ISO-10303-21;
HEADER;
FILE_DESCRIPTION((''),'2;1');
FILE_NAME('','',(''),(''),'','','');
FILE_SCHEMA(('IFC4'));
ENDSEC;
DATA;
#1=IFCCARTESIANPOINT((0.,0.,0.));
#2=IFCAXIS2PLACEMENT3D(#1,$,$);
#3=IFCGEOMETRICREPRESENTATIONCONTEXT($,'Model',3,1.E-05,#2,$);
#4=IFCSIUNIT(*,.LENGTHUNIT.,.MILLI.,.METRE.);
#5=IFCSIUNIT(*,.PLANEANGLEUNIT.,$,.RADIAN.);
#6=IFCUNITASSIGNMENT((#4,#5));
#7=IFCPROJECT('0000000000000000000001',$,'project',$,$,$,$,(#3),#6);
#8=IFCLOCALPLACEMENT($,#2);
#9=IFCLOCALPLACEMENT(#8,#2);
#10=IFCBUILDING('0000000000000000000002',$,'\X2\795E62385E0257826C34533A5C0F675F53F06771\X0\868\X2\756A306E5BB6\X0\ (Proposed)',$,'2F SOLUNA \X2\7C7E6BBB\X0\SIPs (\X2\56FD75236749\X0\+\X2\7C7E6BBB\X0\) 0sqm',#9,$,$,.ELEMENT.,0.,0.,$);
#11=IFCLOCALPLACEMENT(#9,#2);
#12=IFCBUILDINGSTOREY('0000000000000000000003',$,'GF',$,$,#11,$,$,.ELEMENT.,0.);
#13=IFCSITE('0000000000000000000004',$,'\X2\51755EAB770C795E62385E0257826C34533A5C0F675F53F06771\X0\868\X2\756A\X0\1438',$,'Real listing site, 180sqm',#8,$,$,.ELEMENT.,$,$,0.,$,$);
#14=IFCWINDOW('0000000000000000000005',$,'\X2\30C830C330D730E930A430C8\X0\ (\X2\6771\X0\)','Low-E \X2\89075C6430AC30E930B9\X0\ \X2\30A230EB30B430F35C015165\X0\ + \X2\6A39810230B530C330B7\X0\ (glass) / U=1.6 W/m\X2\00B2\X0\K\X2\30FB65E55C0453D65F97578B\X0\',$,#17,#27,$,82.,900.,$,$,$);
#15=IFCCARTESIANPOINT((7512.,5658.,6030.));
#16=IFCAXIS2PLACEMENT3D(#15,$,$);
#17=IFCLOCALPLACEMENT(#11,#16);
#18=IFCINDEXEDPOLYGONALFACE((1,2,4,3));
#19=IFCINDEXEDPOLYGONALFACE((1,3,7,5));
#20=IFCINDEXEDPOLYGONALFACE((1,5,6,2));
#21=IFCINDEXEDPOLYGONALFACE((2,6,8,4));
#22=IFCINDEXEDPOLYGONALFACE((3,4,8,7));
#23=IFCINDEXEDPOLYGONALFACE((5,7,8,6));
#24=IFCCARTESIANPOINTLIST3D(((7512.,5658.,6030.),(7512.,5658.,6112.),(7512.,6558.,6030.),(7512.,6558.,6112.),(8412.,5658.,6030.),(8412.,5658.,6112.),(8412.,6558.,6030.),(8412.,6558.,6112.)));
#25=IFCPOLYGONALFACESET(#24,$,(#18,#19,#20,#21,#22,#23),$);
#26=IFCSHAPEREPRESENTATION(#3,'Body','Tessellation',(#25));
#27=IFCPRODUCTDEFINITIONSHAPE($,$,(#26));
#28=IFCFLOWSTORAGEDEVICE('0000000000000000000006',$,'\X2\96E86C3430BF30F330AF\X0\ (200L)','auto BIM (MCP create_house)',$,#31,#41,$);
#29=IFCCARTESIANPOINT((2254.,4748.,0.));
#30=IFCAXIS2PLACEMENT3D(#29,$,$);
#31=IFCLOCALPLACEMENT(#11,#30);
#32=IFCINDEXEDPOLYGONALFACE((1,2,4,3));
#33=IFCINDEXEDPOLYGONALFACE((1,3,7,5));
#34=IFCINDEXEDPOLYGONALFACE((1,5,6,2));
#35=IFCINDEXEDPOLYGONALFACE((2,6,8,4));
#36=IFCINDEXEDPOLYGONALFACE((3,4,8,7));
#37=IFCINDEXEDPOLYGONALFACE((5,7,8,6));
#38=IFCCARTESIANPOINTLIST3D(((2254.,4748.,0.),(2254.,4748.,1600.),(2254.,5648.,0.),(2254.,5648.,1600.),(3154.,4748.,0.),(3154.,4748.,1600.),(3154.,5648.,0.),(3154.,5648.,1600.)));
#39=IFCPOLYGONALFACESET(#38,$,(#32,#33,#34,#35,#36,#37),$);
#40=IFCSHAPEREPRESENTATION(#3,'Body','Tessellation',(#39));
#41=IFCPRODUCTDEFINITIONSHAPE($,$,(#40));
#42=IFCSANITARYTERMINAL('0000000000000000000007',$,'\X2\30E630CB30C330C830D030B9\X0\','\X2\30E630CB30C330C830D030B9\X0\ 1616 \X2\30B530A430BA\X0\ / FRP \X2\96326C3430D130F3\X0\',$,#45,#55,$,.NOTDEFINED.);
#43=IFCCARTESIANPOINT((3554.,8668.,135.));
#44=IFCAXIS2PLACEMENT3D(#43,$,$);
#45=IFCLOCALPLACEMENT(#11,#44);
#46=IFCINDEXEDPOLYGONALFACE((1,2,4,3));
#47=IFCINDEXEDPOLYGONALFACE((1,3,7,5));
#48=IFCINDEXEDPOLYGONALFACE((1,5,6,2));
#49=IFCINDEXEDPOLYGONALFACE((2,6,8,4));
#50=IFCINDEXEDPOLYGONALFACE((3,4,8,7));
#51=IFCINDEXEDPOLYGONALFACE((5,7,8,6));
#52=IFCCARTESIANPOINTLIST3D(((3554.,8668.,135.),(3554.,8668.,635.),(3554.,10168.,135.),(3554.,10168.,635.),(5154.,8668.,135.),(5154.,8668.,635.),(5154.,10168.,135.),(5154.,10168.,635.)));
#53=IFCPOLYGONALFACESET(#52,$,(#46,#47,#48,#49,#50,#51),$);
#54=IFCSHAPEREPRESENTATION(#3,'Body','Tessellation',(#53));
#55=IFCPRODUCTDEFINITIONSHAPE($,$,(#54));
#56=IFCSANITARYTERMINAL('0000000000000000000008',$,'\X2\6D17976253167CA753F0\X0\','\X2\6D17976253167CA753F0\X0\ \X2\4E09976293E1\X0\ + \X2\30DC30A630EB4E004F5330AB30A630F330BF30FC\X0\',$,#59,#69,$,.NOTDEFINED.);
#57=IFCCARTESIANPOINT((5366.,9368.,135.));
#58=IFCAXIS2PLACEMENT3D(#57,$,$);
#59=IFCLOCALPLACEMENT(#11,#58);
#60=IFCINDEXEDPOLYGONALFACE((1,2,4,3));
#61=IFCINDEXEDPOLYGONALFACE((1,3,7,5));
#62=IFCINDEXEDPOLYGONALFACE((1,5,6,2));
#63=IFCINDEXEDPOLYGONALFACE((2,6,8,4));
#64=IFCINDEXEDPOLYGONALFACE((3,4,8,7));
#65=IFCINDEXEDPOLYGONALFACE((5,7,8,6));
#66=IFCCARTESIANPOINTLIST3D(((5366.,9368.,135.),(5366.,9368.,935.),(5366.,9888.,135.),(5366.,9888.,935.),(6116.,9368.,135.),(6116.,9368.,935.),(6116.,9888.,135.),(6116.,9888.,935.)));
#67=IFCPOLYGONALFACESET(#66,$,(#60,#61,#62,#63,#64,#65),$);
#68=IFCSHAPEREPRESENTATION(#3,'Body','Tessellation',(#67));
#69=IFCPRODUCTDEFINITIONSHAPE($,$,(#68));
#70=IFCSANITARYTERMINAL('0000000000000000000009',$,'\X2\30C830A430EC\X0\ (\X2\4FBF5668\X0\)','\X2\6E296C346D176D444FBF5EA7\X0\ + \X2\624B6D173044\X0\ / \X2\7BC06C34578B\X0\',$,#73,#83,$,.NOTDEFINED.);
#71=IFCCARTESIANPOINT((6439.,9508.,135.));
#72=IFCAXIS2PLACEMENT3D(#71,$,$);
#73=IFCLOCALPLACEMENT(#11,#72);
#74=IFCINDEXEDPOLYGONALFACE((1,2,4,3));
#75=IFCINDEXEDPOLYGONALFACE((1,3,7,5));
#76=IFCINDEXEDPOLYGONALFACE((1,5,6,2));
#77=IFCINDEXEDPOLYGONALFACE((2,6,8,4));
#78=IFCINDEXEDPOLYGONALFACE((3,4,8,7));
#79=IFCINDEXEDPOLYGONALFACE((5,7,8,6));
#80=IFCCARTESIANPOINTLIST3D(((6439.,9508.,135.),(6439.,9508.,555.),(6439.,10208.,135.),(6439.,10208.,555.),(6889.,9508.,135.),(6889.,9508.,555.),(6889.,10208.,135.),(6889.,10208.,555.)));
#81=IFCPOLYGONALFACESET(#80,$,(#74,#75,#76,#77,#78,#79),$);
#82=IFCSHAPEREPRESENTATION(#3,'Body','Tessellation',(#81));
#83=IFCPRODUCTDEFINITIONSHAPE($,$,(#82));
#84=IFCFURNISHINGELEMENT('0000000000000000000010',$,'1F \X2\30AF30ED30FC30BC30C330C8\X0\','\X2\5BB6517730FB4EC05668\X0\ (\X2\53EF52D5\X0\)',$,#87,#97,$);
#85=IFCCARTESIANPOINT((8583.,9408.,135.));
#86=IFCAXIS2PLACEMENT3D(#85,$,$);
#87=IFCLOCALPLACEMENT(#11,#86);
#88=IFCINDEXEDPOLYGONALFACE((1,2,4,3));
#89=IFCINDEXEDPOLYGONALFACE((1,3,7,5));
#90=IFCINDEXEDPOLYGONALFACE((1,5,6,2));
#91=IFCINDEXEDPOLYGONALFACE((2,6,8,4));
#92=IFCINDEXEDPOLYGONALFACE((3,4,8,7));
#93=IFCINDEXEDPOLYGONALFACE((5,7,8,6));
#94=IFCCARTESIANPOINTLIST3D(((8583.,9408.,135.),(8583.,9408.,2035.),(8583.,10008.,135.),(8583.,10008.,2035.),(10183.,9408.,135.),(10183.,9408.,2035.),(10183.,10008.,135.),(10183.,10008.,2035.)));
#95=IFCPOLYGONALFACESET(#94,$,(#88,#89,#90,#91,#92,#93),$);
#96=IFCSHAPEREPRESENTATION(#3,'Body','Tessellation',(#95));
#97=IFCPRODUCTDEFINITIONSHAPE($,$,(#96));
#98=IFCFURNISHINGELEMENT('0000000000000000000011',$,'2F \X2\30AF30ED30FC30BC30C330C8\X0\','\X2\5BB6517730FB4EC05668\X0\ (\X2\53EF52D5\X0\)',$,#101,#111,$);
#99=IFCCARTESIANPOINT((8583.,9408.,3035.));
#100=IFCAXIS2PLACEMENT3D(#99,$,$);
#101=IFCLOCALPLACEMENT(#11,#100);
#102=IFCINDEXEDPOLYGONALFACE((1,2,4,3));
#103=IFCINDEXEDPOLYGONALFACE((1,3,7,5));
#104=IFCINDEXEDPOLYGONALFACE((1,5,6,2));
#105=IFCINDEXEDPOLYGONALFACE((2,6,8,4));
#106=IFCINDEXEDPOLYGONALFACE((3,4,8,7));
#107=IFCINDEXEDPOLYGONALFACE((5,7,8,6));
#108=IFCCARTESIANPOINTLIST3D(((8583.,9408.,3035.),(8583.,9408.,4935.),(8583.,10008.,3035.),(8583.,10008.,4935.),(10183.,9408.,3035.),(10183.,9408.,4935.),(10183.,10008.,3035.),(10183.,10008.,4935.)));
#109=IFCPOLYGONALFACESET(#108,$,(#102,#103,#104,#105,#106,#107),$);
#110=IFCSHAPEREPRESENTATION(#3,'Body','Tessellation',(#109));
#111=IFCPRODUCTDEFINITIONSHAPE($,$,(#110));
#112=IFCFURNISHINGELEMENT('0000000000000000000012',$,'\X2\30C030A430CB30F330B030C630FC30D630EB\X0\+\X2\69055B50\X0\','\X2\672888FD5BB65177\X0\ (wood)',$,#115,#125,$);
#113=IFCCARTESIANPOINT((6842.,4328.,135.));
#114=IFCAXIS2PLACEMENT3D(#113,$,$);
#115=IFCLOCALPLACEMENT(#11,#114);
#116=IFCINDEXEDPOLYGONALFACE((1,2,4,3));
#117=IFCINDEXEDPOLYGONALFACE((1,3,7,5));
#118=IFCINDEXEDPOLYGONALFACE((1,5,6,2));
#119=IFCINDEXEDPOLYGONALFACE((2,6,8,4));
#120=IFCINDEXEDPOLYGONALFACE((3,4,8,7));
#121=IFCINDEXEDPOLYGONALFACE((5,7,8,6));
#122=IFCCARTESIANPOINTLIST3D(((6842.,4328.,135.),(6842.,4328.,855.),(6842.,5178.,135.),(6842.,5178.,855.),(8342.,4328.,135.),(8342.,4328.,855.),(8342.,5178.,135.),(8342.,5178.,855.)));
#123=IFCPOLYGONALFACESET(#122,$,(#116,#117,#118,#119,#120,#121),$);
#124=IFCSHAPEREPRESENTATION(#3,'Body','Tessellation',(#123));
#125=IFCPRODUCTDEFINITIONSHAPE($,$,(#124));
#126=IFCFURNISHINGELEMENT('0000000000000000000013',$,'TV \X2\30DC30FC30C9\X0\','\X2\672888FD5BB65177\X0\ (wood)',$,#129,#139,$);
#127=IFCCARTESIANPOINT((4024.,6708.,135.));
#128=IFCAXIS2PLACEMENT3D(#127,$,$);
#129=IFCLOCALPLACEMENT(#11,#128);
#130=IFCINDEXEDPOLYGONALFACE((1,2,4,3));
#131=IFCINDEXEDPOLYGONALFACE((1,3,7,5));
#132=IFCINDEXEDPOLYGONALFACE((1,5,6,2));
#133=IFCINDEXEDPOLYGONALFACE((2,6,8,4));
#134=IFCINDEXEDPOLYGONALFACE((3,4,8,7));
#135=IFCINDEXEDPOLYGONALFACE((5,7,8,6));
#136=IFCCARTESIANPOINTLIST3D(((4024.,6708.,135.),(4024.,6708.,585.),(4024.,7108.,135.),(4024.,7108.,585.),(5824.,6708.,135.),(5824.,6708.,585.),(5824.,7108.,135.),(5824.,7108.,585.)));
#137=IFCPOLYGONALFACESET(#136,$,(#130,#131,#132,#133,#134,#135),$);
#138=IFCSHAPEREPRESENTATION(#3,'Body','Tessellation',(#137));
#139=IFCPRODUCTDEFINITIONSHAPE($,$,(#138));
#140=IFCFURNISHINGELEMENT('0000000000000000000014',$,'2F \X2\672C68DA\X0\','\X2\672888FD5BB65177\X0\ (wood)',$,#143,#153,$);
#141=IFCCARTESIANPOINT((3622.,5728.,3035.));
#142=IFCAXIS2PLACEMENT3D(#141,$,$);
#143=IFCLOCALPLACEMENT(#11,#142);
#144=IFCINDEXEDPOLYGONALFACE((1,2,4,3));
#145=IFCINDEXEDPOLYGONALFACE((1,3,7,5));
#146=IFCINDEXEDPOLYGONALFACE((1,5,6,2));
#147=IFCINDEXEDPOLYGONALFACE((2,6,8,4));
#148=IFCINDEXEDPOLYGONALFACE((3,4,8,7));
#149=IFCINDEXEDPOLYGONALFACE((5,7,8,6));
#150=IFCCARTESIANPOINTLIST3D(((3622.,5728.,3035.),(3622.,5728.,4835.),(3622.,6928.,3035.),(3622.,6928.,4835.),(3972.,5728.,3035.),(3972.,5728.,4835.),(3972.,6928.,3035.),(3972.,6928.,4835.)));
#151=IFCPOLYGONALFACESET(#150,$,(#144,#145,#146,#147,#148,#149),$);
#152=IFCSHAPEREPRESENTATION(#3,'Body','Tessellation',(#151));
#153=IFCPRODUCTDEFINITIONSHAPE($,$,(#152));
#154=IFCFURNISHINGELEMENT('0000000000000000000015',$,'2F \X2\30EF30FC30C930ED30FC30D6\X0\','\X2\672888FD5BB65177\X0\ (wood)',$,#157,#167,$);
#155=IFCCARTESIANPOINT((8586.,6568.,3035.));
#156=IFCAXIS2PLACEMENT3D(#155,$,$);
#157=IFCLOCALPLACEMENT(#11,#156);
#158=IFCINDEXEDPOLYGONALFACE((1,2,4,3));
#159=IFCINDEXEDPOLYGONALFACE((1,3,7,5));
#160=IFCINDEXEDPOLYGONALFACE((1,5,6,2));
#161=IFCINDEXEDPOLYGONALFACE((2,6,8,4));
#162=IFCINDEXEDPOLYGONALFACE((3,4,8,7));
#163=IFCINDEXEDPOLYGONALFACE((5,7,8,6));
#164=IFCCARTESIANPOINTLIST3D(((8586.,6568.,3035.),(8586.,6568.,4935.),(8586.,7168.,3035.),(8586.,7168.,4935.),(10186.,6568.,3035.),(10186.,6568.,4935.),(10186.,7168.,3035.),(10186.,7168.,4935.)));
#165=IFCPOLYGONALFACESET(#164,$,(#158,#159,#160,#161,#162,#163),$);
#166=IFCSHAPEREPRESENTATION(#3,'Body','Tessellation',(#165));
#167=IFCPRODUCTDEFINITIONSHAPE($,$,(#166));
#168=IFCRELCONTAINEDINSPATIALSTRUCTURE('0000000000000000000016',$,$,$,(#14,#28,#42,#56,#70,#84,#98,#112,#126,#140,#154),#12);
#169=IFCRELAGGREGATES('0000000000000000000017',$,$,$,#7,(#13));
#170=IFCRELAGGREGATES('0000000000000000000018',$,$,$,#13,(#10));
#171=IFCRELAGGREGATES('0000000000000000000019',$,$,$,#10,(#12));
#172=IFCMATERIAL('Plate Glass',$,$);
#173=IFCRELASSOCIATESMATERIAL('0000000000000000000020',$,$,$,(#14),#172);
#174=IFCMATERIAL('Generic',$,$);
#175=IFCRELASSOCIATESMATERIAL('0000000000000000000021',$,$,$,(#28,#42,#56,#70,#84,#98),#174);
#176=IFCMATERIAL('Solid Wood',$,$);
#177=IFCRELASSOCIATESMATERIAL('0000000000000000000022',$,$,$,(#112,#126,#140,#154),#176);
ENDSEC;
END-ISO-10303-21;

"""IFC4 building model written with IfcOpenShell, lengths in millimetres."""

from ifc_helpers import new_model, si_unit, frame, frame_2d, origin, place, context, project, spatial, rectangle, extrude, material, element, save


model = new_model("IFC4")

# Units and contexts
model_context = context("Model", 3, precision=1e-05, world=origin())
ifc_project = project(units=[si_unit("LENGTHUNIT", "METRE", prefix="MILLI"), si_unit("PLANEANGLEUNIT", "RADIAN")], contexts=[model_context])

# Site, building, storey
site_placement = place(None, origin())
site = spatial("IfcSite", under=ifc_project, at=site_placement, Name="兵庫県神戸市垂水区小束台東868番1438", ObjectType="Real listing site, 180sqm", CompositionType="ELEMENT", RefElevation=0.0)
building_placement = place(site_placement, origin())
building = spatial("IfcBuilding", under=site, at=building_placement, Name="神戸市垂水区小束台東868番の家 (Proposed)", ObjectType="2F SOLUNA 籾殻SIPs (国産杉+籾殻) 0sqm", CompositionType="ELEMENT", ElevationOfRefHeight=0.0, ElevationOfTerrain=0.0)
storey_placement = place(building_placement, origin())
storey = spatial("IfcBuildingStorey", under=building, at=storey_placement, Name="GF", CompositionType="ELEMENT", Elevation=0.0)

# Shared definitions
ifc_material_1 = material(Name="Solid Wood")
ifc_material_2 = material(Name="Plate Glass")

# Window
window_1_placement = place(storey_placement, frame((7512.0, 5658.0, 6030.0)))
element("IfcWindow", 1, at=window_1_placement, inside=storey, material=ifc_material_2, Name="トップライト (東)", Description="Low-E 複層ガラス アルゴン封入 + 樹脂サッシ (glass) / U=1.6 W/m²K・日射取得型", OverallHeight=82.0, OverallWidth=900.0, context=model_context, shape_type="SweptSolid", body=[
    extrude(rectangle(XDim=900.0, YDim=900.0, at=frame_2d((450.0, 450.0))), frame((7512.0, 5658.0, 6030.0)), (0.0, 0.0, 1.0), 82.0),
])

# Flow storage device
ifc_material_3 = material(Name="Generic")
flow_storage_device_placement = place(storey_placement, frame((2254.0, 4748.0, 0.0)))
element("IfcFlowStorageDevice", 2, at=flow_storage_device_placement, inside=storey, material=ifc_material_3, Name="雨水タンク (200L)", Description="auto BIM (MCP create_house)", context=model_context, shape_type="SweptSolid", body=[
    extrude(rectangle(XDim=900.0, YDim=900.0, at=frame_2d((450.0, 450.0))), frame((2254.0, 4748.0, 0.0)), (0.0, 0.0, 1.0), 1600.0),
])

# Sanitary terminals
sanitary_terminal_1_placement = place(storey_placement, frame((3554.0, 8668.0, 135.0)))
element("IfcSanitaryTerminal", 3, at=sanitary_terminal_1_placement, inside=storey, material=ifc_material_3, Name="ユニットバス", Description="ユニットバス 1616 サイズ / FRP 防水パン", PredefinedType="NOTDEFINED", context=model_context, shape_type="SweptSolid", body=[
    extrude(rectangle(XDim=1600.0, YDim=1500.0, at=frame_2d((800.0, 750.0))), frame((3554.0, 8668.0, 135.0)), (0.0, 0.0, 1.0), 500.0),
])
sanitary_terminal_2_placement = place(storey_placement, frame((5366.0, 9368.0, 135.0)))
element("IfcSanitaryTerminal", 4, at=sanitary_terminal_2_placement, inside=storey, material=ifc_material_3, Name="洗面化粧台", Description="洗面化粧台 三面鏡 + ボウル一体カウンター", PredefinedType="NOTDEFINED", context=model_context, shape_type="SweptSolid", body=[
    extrude(rectangle(XDim=750.0, YDim=520.0, at=frame_2d((375.0, 260.0))), frame((5366.0, 9368.0, 135.0)), (0.0, 0.0, 1.0), 800.0),
])
sanitary_terminal_3_placement = place(storey_placement, frame((6439.0, 9508.0, 135.0)))
element("IfcSanitaryTerminal", 5, at=sanitary_terminal_3_placement, inside=storey, material=ifc_material_3, Name="トイレ (便器)", Description="温水洗浄便座 + 手洗い / 節水型", PredefinedType="NOTDEFINED", context=model_context, shape_type="SweptSolid", body=[
    extrude(rectangle(XDim=450.0, YDim=700.0, at=frame_2d((225.0, 350.0))), frame((6439.0, 9508.0, 135.0)), (0.0, 0.0, 1.0), 420.0),
])

# Furnishing elements
furnishing_1_placement = place(storey_placement, frame((8583.0, 9408.0, 135.0)))
element("IfcFurnishingElement", 6, at=furnishing_1_placement, inside=storey, material=ifc_material_3, Name="1F クローゼット", Description="家具・什器 (可動)", context=model_context, shape_type="SweptSolid", body=[
    extrude(rectangle(XDim=1600.0, YDim=600.0, at=frame_2d((800.0, 300.0))), frame((8583.0, 9408.0, 135.0)), (0.0, 0.0, 1.0), 1900.0),
])
furnishing_2_placement = place(storey_placement, frame((8583.0, 9408.0, 3035.0)))
element("IfcFurnishingElement", 7, at=furnishing_2_placement, inside=storey, material=ifc_material_3, Name="2F クローゼット", Description="家具・什器 (可動)", context=model_context, shape_type="SweptSolid", body=[
    extrude(rectangle(XDim=1600.0, YDim=600.0, at=frame_2d((800.0, 300.0))), frame((8583.0, 9408.0, 3035.0)), (0.0, 0.0, 1.0), 1900.0),
])
furnishing_3_placement = place(storey_placement, frame((6842.0, 4328.0, 135.0)))
element("IfcFurnishingElement", 8, at=furnishing_3_placement, inside=storey, material=ifc_material_1, Name="ダイニングテーブル+椅子", Description="木製家具 (wood)", context=model_context, shape_type="SweptSolid", body=[
    extrude(rectangle(XDim=1500.0, YDim=850.0, at=frame_2d((750.0, 425.0))), frame((6842.0, 4328.0, 135.0)), (0.0, 0.0, 1.0), 720.0),
])
furnishing_4_placement = place(storey_placement, frame((4024.0, 6708.0, 135.0)))
element("IfcFurnishingElement", 9, at=furnishing_4_placement, inside=storey, material=ifc_material_1, Name="TV ボード", Description="木製家具 (wood)", context=model_context, shape_type="SweptSolid", body=[
    extrude(rectangle(XDim=1800.0, YDim=400.0, at=frame_2d((900.0, 200.0))), frame((4024.0, 6708.0, 135.0)), (0.0, 0.0, 1.0), 450.0),
])
furnishing_5_placement = place(storey_placement, frame((3622.0, 5728.0, 3035.0)))
element("IfcFurnishingElement", 10, at=furnishing_5_placement, inside=storey, material=ifc_material_1, Name="2F 本棚", Description="木製家具 (wood)", context=model_context, shape_type="SweptSolid", body=[
    extrude(rectangle(XDim=350.0, YDim=1200.0, at=frame_2d((175.0, 600.0))), frame((3622.0, 5728.0, 3035.0)), (0.0, 0.0, 1.0), 1800.0),
])
furnishing_6_placement = place(storey_placement, frame((8586.0, 6568.0, 3035.0)))
element("IfcFurnishingElement", 11, at=furnishing_6_placement, inside=storey, material=ifc_material_1, Name="2F ワードローブ", Description="木製家具 (wood)", context=model_context, shape_type="SweptSolid", body=[
    extrude(rectangle(XDim=1600.0, YDim=600.0, at=frame_2d((800.0, 300.0))), frame((8586.0, 6568.0, 3035.0)), (0.0, 0.0, 1.0), 1900.0),
])

save(model, "model.ifc")
